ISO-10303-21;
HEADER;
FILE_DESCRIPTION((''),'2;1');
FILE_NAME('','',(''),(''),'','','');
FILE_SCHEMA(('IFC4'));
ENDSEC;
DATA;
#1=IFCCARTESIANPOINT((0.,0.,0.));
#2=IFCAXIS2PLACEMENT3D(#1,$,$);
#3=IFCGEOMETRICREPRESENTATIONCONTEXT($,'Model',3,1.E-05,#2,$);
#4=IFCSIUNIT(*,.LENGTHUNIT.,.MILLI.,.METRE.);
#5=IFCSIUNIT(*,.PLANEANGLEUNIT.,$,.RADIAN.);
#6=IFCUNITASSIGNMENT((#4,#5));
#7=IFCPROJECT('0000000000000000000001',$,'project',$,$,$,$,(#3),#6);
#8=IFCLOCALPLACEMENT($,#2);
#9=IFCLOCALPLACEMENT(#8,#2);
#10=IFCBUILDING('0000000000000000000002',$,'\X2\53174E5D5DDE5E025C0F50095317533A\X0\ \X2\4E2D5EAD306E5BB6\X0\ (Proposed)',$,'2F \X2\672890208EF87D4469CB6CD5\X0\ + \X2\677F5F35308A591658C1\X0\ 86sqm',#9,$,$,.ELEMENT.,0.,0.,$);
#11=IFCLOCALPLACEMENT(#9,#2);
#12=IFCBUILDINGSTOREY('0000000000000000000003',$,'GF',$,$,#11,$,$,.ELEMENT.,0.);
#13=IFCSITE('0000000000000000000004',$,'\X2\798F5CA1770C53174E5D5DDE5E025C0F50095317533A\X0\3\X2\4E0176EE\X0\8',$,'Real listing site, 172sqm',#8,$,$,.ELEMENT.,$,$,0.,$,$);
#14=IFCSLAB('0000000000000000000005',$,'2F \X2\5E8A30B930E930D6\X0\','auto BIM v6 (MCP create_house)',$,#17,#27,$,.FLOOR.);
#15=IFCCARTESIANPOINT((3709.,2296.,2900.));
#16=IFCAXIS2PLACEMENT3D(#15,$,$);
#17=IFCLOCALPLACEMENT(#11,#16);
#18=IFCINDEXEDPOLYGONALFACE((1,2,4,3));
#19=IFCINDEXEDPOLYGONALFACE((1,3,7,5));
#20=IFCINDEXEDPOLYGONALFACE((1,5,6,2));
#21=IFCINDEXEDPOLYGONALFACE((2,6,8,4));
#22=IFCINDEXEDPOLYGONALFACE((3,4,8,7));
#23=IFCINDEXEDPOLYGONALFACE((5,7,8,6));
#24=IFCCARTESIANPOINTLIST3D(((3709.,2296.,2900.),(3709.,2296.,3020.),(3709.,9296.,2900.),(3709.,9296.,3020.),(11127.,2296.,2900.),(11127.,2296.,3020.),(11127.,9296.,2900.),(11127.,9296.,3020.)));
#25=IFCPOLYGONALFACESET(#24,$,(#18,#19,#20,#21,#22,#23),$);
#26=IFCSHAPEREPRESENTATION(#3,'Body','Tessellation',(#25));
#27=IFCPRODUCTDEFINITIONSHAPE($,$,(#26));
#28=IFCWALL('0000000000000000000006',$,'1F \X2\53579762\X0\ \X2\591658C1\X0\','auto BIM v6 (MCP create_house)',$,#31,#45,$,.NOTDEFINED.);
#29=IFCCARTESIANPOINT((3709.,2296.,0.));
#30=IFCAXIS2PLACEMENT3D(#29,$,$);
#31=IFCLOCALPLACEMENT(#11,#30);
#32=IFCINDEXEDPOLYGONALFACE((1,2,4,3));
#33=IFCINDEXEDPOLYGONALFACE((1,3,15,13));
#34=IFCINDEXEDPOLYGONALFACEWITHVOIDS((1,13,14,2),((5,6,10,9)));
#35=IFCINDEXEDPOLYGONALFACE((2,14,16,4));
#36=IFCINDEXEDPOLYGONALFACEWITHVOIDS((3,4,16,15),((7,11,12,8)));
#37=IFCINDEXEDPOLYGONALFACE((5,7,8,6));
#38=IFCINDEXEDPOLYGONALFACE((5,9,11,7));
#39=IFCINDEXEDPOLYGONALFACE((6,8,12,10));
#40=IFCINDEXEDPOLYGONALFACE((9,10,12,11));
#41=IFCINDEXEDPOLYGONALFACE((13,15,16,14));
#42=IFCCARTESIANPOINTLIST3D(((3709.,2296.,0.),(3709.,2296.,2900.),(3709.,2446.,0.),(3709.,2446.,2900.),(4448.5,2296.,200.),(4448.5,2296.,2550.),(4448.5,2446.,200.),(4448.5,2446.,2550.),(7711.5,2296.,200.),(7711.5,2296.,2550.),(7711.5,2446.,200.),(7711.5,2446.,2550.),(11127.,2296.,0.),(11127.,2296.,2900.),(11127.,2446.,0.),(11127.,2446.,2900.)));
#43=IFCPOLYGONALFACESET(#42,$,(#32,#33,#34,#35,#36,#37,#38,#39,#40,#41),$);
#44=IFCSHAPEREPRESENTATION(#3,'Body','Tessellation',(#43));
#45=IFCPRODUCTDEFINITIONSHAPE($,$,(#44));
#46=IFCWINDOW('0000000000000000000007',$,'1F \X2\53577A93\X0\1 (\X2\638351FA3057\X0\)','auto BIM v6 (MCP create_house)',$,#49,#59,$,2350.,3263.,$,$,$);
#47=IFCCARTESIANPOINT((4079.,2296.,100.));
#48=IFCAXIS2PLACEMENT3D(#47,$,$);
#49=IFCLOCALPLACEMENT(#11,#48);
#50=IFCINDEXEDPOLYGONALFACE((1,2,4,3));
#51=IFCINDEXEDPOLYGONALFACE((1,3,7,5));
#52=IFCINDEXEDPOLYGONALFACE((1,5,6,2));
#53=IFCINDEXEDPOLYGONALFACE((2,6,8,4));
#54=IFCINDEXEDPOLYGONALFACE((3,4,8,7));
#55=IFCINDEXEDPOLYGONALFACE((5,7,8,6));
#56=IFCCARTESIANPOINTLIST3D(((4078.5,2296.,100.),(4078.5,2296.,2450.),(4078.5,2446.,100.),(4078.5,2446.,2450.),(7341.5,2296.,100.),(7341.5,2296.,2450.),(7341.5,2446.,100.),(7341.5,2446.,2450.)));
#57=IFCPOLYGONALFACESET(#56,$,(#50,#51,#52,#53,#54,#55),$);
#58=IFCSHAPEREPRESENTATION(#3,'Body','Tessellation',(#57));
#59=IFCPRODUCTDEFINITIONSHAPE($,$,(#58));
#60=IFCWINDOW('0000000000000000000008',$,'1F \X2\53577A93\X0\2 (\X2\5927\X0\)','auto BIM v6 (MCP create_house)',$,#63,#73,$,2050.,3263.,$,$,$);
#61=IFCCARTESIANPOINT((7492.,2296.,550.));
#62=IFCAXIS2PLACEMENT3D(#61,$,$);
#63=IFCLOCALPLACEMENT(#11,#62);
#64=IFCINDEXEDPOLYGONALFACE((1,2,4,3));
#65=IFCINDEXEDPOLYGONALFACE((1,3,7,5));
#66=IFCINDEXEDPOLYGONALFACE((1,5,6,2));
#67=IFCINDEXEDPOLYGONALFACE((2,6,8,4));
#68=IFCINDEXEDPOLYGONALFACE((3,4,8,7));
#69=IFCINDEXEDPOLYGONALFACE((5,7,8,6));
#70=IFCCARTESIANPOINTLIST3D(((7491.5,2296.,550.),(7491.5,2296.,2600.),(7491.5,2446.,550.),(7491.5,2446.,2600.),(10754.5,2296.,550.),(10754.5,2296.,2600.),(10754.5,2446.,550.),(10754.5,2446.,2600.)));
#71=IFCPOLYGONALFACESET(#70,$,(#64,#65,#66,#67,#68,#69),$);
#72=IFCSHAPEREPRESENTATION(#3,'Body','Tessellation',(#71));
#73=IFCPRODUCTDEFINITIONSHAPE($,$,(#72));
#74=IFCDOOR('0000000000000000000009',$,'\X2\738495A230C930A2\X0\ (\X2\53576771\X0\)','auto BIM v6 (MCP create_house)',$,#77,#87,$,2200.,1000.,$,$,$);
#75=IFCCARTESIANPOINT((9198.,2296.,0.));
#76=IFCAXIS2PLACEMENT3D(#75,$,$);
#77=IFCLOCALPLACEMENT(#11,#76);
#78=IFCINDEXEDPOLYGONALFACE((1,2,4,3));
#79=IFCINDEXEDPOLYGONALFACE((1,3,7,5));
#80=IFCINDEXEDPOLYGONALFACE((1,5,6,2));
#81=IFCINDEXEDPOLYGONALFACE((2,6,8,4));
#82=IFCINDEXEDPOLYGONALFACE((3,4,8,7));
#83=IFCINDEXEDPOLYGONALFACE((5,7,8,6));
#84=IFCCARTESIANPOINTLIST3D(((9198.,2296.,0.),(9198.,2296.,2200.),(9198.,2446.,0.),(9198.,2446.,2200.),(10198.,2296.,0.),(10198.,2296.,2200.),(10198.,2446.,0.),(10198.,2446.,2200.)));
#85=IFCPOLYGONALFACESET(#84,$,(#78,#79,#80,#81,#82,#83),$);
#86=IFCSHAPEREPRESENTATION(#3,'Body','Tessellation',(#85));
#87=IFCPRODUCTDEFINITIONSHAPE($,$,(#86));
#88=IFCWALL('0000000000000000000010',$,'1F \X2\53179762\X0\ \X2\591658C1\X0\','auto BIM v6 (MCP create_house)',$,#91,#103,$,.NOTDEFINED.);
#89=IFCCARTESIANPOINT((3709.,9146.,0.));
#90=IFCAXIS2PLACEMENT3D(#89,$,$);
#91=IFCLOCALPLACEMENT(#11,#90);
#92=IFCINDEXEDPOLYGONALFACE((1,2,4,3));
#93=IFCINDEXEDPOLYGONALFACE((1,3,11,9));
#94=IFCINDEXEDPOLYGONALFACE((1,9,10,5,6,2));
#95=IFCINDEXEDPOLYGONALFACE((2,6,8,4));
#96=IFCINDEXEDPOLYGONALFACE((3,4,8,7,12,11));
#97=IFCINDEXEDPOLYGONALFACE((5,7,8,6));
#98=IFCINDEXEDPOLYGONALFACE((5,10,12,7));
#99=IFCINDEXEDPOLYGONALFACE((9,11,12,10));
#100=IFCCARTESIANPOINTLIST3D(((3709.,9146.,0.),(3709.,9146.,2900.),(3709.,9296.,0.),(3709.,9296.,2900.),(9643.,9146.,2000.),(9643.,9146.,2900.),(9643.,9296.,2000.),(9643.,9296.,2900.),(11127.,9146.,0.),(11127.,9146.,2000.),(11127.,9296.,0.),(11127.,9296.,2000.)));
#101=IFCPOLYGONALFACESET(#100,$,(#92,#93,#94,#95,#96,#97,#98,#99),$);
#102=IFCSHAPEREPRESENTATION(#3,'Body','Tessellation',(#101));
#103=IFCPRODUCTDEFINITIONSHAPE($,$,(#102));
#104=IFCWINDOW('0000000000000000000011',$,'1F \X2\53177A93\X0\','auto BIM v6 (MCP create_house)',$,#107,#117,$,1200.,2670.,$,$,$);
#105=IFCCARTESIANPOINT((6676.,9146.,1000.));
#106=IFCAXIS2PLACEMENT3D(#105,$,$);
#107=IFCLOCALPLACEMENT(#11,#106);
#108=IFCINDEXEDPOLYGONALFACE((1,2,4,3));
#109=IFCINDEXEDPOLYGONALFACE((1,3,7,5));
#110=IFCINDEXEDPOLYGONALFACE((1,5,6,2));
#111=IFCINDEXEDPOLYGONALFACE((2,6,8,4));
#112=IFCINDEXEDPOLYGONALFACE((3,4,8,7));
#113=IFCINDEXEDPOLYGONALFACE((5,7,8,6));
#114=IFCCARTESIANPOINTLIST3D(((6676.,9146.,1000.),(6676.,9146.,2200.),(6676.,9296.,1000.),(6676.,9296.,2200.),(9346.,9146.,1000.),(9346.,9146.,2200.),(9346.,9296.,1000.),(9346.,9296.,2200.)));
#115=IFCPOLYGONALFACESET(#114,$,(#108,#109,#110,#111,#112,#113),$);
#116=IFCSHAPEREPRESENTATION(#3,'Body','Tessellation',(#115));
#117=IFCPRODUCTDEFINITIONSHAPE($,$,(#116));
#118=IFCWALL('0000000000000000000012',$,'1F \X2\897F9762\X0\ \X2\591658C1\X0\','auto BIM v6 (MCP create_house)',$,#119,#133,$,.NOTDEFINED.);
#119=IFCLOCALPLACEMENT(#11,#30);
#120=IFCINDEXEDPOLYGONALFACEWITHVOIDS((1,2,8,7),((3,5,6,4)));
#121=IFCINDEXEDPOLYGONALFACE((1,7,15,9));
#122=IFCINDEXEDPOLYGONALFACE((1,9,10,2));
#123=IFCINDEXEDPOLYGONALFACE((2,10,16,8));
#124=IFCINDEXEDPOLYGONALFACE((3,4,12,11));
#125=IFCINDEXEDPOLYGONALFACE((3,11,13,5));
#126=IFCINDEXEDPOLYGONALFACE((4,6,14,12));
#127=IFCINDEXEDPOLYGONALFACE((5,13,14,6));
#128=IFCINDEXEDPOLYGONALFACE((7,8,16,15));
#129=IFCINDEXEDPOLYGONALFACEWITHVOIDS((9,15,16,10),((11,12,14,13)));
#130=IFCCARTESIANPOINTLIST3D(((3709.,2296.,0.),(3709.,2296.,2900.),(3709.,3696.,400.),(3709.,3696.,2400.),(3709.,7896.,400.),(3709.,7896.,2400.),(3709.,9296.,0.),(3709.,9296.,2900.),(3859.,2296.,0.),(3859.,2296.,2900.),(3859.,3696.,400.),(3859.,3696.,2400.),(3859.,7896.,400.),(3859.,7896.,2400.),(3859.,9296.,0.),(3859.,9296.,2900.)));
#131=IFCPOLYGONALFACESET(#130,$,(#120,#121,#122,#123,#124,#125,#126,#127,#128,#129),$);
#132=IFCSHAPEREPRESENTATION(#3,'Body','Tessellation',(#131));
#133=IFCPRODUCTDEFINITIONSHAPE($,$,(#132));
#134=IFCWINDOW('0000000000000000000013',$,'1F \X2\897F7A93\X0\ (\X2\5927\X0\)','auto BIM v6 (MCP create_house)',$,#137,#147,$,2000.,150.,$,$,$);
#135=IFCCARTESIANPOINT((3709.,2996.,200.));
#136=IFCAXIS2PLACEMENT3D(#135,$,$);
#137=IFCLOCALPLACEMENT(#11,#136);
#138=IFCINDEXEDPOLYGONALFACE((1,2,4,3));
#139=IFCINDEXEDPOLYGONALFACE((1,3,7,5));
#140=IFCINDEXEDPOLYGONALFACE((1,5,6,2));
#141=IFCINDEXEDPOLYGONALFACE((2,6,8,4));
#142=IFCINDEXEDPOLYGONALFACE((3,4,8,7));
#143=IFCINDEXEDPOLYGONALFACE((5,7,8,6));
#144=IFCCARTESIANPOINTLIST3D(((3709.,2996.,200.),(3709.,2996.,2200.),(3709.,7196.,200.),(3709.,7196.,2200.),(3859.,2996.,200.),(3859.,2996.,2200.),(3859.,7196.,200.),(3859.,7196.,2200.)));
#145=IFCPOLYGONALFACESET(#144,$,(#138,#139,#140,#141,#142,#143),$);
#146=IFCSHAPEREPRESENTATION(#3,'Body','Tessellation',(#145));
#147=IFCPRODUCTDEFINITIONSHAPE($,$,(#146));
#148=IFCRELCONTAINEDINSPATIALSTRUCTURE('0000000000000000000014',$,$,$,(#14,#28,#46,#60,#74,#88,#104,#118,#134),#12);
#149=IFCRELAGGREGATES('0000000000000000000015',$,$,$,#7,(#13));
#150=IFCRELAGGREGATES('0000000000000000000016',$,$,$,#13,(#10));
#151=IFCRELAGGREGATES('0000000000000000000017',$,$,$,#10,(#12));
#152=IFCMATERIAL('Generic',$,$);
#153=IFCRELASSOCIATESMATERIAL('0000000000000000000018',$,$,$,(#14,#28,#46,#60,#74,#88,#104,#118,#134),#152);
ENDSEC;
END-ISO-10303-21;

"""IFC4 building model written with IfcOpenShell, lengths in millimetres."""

from ifc_helpers import new_model, si_unit, frame, frame_2d, origin, place, context, project, spatial, rectangle, extrude, material, element, fill, save


model = new_model("IFC4")

# Units and contexts
model_context = context("Model", 3, precision=1e-05, world=origin())
ifc_project = project(units=[si_unit("LENGTHUNIT", "METRE", prefix="MILLI"), si_unit("PLANEANGLEUNIT", "RADIAN")], contexts=[model_context])

# Site, building, storey
site_placement = place(None, origin())
site = spatial("IfcSite", under=ifc_project, at=site_placement, Name="福岡県北九州市小倉北区3丁目8", ObjectType="Real listing site, 172sqm", CompositionType="ELEMENT", RefElevation=0.0)
building_placement = place(site_placement, origin())
building = spatial("IfcBuilding", under=site, at=building_placement, Name="北九州市小倉北区 中庭の家 (Proposed)", ObjectType="2F 木造軸組構法 + 板張り外壁 86sqm", CompositionType="ELEMENT", ElevationOfRefHeight=0.0, ElevationOfTerrain=0.0)
storey_placement = place(building_placement, origin())
storey = spatial("IfcBuildingStorey", under=building, at=storey_placement, Name="GF", CompositionType="ELEMENT", Elevation=0.0)

# Slab
ifc_material = material(Name="Generic")
slab_1_placement = place(storey_placement, frame((3709.0, 2296.0, 2900.0)))
element("IfcSlab", 1, at=slab_1_placement, inside=storey, material=ifc_material, Name="2F 床スラブ", Description="auto BIM v6 (MCP create_house)", PredefinedType="FLOOR", context=model_context, shape_type="SweptSolid", body=[
    extrude(rectangle(XDim=7418.0, YDim=7000.0, at=frame_2d((3709.0, 3500.0))), frame((3709.0, 2296.0, 2900.0)), (0.0, 0.0, 1.0), 120.0),
])

# Wall, openings, windows, door
wall_1_placement = place(storey_placement, frame((3709.0, 2296.0, 0.0)))
wall_1 = element("IfcWall", 2, at=wall_1_placement, inside=storey, material=ifc_material, Name="1F 南面 外壁", Description="auto BIM v6 (MCP create_house)", PredefinedType="NOTDEFINED", context=model_context, shape_type="SweptSolid", body=[
    extrude(rectangle(XDim=7418.0, YDim=150.0, at=frame_2d((3709.0, 75.0))), frame((3709.0, 2296.0, 0.0)), (0.0, 0.0, 1.0), 2900.0),
])
opening_1_placement = place(storey_placement, frame((4079.0, 2296.0, 100.0)))
opening_1 = element("IfcOpeningElement", 3, at=opening_1_placement, cuts=wall_1, PredefinedType="NOTDEFINED", context=model_context, shape_type="SweptSolid", body=[
    extrude(rectangle(XDim=3263.0, YDim=150.0, at=frame_2d((1631.0, 75.0))), frame((4079.0, 2296.0, 100.0)), (0.0, 0.0, 1.0), 2350.0),
])
opening_2_placement = place(storey_placement, frame((7492.0, 2296.0, 550.0)))
opening_2 = element("IfcOpeningElement", 4, at=opening_2_placement, cuts=wall_1, PredefinedType="NOTDEFINED", context=model_context, shape_type="SweptSolid", body=[
    extrude(rectangle(XDim=3263.0, YDim=150.0, at=frame_2d((1631.0, 75.0))), frame((7492.0, 2296.0, 550.0)), (0.0, 0.0, 1.0), 2050.0),
])
opening_3_placement = place(storey_placement, frame((9198.0, 2296.0, 0.0)))
opening_3 = element("IfcOpeningElement", 5, at=opening_3_placement, cuts=wall_1, PredefinedType="NOTDEFINED", context=model_context, shape_type="SweptSolid", body=[
    extrude(rectangle(XDim=1000.0, YDim=150.0, at=frame_2d((500.0, 75.0))), frame((9198.0, 2296.0, 0.0)), (0.0, 0.0, 1.0), 2200.0),
])
window_1_placement = place(storey_placement, frame((4079.0, 2296.0, 100.0)))
window_1 = element("IfcWindow", 6, at=window_1_placement, inside=storey, material=ifc_material, Name="1F 南窓1 (掃出し)", Description="auto BIM v6 (MCP create_house)", OverallHeight=2350.0, OverallWidth=3263.0, context=model_context, shape_type="SweptSolid", body=[
    extrude(rectangle(XDim=3263.0, YDim=150.0, at=frame_2d((1631.0, 75.0))), frame((4079.0, 2296.0, 100.0)), (0.0, 0.0, 1.0), 2350.0),
])
fill(opening_1, window_1)
window_2_placement = place(storey_placement, frame((7492.0, 2296.0, 550.0)))
window_2 = element("IfcWindow", 7, at=window_2_placement, inside=storey, material=ifc_material, Name="1F 南窓2 (大)", Description="auto BIM v6 (MCP create_house)", OverallHeight=2050.0, OverallWidth=3263.0, context=model_context, shape_type="SweptSolid", body=[
    extrude(rectangle(XDim=3263.0, YDim=150.0, at=frame_2d((1631.0, 75.0))), frame((7492.0, 2296.0, 550.0)), (0.0, 0.0, 1.0), 2050.0),
])
fill(opening_2, window_2)
door_placement = place(storey_placement, frame((9198.0, 2296.0, 0.0)))
door = element("IfcDoor", 8, at=door_placement, inside=storey, material=ifc_material, Name="玄関ドア (南東)", Description="auto BIM v6 (MCP create_house)", OverallHeight=2200.0, OverallWidth=1000.0, context=model_context, shape_type="SweptSolid", body=[
    extrude(rectangle(XDim=1000.0, YDim=150.0, at=frame_2d((500.0, 75.0))), frame((9198.0, 2296.0, 0.0)), (0.0, 0.0, 1.0), 2200.0),
])
fill(opening_3, door)

# Walls, openings, windows
wall_2_placement = place(storey_placement, frame((3709.0, 9146.0, 0.0)))
wall_2 = element("IfcWall", 9, at=wall_2_placement, inside=storey, material=ifc_material, Name="1F 北面 外壁", Description="auto BIM v6 (MCP create_house)", PredefinedType="NOTDEFINED", context=model_context, shape_type="SweptSolid", body=[
    extrude(rectangle(XDim=7418.0, YDim=150.0, at=frame_2d((3709.0, 75.0))), frame((3709.0, 9146.0, 0.0)), (0.0, 0.0, 1.0), 2900.0),
])
opening_4_placement = place(storey_placement, frame((6676.0, 9146.0, 1000.0)))
opening_4 = element("IfcOpeningElement", 10, at=opening_4_placement, cuts=wall_2, PredefinedType="NOTDEFINED", context=model_context, shape_type="SweptSolid", body=[
    extrude(rectangle(XDim=2670.0, YDim=150.0, at=frame_2d((1335.0, 75.0))), frame((6676.0, 9146.0, 1000.0)), (0.0, 0.0, 1.0), 1200.0),
])
window_3_placement = place(storey_placement, frame((6676.0, 9146.0, 1000.0)))
window_3 = element("IfcWindow", 11, at=window_3_placement, inside=storey, material=ifc_material, Name="1F 北窓", Description="auto BIM v6 (MCP create_house)", OverallHeight=1200.0, OverallWidth=2670.0, context=model_context, shape_type="SweptSolid", body=[
    extrude(rectangle(XDim=2670.0, YDim=150.0, at=frame_2d((1335.0, 75.0))), frame((6676.0, 9146.0, 1000.0)), (0.0, 0.0, 1.0), 1200.0),
])
fill(opening_4, window_3)
wall_3_placement = place(storey_placement, frame((3709.0, 2296.0, 0.0)))
wall_3 = element("IfcWall", 12, at=wall_3_placement, inside=storey, material=ifc_material, Name="1F 西面 外壁", Description="auto BIM v6 (MCP create_house)", PredefinedType="NOTDEFINED", context=model_context, shape_type="SweptSolid", body=[
    extrude(rectangle(XDim=150.0, YDim=7000.0, at=frame_2d((75.0, 3500.0))), frame((3709.0, 2296.0, 0.0)), (0.0, 0.0, 1.0), 2900.0),
])
opening_5_placement = place(storey_placement, frame((3709.0, 2996.0, 200.0)))
opening_5 = element("IfcOpeningElement", 13, at=opening_5_placement, cuts=wall_3, PredefinedType="NOTDEFINED", context=model_context, shape_type="SweptSolid", body=[
    extrude(rectangle(XDim=150.0, YDim=4200.0, at=frame_2d((75.0, 2100.0))), frame((3709.0, 2996.0, 200.0)), (0.0, 0.0, 1.0), 2000.0),
])
window_4_placement = place(storey_placement, frame((3709.0, 2996.0, 200.0)))
window_4 = element("IfcWindow", 14, at=window_4_placement, inside=storey, material=ifc_material, Name="1F 西窓 (大)", Description="auto BIM v6 (MCP create_house)", OverallHeight=2000.0, OverallWidth=150.0, context=model_context, shape_type="SweptSolid", body=[
    extrude(rectangle(XDim=150.0, YDim=4200.0, at=frame_2d((75.0, 2100.0))), frame((3709.0, 2996.0, 200.0)), (0.0, 0.0, 1.0), 2000.0),
])
fill(opening_5, window_4)

save(model, "model.ifc")
